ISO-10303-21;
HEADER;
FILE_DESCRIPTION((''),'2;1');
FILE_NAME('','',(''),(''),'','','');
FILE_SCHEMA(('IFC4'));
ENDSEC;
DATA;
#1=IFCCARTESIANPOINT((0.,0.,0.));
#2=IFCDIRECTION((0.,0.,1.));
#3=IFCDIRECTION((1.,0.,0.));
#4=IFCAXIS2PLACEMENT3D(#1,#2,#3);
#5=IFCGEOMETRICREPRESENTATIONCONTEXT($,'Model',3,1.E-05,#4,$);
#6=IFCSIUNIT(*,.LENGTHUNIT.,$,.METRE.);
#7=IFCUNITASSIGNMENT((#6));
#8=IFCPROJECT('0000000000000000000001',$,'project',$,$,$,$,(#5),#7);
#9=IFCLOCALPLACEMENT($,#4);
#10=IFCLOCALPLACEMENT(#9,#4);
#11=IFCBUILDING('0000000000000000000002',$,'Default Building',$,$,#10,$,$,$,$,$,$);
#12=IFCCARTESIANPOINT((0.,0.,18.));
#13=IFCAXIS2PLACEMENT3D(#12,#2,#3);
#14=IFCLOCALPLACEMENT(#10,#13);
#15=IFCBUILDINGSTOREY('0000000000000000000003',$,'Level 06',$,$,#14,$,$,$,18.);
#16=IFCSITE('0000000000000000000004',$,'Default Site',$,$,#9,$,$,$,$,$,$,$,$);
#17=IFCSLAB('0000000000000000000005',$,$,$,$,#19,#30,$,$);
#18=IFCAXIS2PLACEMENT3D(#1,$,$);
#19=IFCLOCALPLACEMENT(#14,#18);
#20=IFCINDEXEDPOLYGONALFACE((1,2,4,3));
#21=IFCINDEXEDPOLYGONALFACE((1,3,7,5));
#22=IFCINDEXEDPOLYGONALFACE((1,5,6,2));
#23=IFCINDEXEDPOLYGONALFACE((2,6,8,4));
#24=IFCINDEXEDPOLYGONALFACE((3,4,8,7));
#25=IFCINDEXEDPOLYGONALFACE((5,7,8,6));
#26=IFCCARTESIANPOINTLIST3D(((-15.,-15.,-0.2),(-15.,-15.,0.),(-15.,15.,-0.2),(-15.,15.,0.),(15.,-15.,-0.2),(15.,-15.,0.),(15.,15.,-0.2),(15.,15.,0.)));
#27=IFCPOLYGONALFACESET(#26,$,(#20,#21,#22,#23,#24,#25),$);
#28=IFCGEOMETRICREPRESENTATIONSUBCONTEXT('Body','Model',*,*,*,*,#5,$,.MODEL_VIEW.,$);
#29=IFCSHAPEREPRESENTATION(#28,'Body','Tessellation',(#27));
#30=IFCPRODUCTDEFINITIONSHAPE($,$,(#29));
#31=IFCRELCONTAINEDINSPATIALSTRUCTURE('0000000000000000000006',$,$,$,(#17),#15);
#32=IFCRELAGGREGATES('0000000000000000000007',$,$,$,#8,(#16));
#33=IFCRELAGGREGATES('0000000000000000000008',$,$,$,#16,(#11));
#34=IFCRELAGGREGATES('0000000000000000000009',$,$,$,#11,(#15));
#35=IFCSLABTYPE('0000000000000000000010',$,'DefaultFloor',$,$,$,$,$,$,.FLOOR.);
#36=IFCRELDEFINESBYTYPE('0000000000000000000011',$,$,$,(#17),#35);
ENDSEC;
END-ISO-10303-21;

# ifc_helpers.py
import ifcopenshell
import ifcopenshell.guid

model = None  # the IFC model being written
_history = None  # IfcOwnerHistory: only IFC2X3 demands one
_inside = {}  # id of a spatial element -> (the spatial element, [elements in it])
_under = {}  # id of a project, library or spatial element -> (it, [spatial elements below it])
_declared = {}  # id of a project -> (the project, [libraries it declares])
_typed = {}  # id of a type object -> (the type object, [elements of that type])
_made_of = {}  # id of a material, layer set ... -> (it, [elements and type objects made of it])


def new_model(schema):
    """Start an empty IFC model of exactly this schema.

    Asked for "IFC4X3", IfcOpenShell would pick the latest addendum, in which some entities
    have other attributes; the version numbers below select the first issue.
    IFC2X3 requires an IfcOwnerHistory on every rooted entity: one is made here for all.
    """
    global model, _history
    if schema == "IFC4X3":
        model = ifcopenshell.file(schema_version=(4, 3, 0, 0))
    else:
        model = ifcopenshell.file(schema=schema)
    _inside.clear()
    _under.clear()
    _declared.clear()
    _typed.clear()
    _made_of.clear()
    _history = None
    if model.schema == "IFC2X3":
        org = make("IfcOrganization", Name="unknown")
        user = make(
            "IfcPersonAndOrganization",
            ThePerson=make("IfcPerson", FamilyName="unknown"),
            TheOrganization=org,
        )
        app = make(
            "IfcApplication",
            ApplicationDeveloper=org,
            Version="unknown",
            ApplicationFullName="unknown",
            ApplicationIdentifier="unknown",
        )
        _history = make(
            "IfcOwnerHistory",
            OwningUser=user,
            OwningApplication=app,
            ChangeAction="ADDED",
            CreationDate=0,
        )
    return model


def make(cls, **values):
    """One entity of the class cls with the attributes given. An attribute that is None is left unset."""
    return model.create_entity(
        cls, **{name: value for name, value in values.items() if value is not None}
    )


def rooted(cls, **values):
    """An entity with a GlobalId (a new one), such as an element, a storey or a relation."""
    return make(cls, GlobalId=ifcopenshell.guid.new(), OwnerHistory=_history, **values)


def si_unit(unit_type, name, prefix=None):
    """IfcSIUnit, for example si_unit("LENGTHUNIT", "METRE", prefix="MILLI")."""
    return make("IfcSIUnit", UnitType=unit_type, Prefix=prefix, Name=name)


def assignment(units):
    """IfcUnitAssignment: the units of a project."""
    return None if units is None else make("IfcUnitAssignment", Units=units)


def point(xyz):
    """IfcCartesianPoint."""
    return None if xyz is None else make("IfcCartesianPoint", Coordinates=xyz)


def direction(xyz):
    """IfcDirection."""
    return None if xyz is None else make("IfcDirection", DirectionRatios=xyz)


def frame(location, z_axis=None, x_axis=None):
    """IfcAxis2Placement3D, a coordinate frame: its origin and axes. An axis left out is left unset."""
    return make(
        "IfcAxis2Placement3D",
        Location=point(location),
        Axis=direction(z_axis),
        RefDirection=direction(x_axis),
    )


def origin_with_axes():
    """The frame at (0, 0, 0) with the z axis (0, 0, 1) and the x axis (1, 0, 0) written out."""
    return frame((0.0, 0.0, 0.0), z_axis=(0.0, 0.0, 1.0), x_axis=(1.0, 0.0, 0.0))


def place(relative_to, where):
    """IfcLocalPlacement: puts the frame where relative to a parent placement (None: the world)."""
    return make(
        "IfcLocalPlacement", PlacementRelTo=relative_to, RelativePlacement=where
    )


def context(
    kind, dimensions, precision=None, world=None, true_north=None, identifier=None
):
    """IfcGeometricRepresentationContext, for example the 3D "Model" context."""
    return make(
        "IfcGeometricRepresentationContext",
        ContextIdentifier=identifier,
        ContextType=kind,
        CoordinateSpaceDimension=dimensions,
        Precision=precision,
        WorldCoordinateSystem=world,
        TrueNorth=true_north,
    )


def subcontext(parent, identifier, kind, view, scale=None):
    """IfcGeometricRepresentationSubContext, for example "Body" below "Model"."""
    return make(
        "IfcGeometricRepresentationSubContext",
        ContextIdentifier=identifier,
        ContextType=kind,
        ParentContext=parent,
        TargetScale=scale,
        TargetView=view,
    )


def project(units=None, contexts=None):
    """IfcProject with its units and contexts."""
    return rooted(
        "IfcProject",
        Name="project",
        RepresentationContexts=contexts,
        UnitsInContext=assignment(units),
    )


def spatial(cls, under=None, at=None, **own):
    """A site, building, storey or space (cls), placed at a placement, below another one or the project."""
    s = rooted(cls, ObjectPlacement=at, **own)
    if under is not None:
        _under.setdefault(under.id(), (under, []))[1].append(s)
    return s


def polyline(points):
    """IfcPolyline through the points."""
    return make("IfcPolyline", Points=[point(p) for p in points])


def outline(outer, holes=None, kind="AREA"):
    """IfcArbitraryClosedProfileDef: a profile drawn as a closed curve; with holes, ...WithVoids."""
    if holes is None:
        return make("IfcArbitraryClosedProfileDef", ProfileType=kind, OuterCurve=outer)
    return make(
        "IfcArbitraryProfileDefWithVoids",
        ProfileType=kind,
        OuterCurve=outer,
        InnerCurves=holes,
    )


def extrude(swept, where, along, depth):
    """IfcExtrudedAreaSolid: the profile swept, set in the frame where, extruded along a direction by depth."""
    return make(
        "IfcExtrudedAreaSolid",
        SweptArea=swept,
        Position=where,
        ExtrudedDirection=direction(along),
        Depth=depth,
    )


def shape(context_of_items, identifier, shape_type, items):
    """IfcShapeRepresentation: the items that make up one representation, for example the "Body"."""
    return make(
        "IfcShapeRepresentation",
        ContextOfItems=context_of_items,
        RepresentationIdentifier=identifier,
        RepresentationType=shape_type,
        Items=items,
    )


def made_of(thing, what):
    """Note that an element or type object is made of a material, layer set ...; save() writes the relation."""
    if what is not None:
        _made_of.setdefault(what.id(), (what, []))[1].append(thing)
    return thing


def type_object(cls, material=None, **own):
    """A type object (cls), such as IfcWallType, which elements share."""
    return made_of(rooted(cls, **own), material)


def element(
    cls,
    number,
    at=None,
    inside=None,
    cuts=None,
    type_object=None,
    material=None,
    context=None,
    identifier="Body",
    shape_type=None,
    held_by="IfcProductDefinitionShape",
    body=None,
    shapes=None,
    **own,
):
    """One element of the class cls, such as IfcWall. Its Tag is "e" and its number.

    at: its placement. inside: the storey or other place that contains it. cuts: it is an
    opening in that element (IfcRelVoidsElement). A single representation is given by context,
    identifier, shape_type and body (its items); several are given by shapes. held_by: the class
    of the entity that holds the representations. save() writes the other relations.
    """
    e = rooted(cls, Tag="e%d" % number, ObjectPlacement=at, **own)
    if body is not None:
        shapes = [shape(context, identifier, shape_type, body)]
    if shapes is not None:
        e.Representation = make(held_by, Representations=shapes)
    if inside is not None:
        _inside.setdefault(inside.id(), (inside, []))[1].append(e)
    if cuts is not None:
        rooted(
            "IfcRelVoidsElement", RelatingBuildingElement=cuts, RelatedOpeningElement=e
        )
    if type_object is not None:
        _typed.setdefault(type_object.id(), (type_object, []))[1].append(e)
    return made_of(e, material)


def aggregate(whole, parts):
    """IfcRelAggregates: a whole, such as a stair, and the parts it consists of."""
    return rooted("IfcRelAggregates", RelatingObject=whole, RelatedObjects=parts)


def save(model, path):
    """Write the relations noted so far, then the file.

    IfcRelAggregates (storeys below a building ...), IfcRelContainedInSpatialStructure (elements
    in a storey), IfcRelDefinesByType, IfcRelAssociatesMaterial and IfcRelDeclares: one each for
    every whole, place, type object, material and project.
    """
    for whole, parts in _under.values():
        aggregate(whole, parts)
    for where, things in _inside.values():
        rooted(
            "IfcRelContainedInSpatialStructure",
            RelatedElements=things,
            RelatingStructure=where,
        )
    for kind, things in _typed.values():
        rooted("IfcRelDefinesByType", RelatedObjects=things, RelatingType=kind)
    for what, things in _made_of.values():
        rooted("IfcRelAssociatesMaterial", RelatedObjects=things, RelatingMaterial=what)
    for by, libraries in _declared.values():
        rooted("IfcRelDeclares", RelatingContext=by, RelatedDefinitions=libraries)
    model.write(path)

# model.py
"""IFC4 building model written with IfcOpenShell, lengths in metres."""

from ifc_helpers import new_model, si_unit, frame, origin_with_axes, place, context, subcontext, project, spatial, polyline, outline, extrude, type_object, element, save


model = new_model("IFC4")

# Units and contexts
model_context = context("Model", 3, precision=1e-05, world=origin_with_axes())
body_context = subcontext(model_context, "Body", "Model", "MODEL_VIEW")
ifc_project = project(units=[si_unit("LENGTHUNIT", "METRE")], contexts=[model_context])

# Site, building, storey
site_placement = place(None, origin_with_axes())
site = spatial("IfcSite", under=ifc_project, at=site_placement, Name="Default Site")
building_placement = place(site_placement, origin_with_axes())
building = spatial("IfcBuilding", under=site, at=building_placement, Name="Default Building")
storey_placement = place(building_placement, frame((0.0, 0.0, 18.0), z_axis=(0.0, 0.0, 1.0), x_axis=(1.0, 0.0, 0.0)))
storey = spatial("IfcBuildingStorey", under=building, at=storey_placement, Name="Level 06", Elevation=18.0)

# Slab
slab_type = type_object("IfcSlabType", Name="DefaultFloor", PredefinedType="FLOOR")
slab_placement = place(storey_placement, frame((0.0, 0.0, -18.0), z_axis=(0.0, 0.0, 1.0), x_axis=(1.0, 0.0, 0.0)))
element("IfcSlab", 1, at=slab_placement, inside=storey, type_object=slab_type, context=body_context, shape_type="SweptSolid", body=[
    extrude(outline(polyline([(-15.0, 15.0), (15.0, 15.0), (15.0, -15.0), (-15.0, -15.0), (-15.0, 15.0)])), frame((0.0, 0.0, 18.0), z_axis=(0.0, 0.0, 1.0), x_axis=(1.0, 0.0, 0.0)), (0.0, 0.0, -1.0), 0.2),
])

save(model, "model.ifc")
